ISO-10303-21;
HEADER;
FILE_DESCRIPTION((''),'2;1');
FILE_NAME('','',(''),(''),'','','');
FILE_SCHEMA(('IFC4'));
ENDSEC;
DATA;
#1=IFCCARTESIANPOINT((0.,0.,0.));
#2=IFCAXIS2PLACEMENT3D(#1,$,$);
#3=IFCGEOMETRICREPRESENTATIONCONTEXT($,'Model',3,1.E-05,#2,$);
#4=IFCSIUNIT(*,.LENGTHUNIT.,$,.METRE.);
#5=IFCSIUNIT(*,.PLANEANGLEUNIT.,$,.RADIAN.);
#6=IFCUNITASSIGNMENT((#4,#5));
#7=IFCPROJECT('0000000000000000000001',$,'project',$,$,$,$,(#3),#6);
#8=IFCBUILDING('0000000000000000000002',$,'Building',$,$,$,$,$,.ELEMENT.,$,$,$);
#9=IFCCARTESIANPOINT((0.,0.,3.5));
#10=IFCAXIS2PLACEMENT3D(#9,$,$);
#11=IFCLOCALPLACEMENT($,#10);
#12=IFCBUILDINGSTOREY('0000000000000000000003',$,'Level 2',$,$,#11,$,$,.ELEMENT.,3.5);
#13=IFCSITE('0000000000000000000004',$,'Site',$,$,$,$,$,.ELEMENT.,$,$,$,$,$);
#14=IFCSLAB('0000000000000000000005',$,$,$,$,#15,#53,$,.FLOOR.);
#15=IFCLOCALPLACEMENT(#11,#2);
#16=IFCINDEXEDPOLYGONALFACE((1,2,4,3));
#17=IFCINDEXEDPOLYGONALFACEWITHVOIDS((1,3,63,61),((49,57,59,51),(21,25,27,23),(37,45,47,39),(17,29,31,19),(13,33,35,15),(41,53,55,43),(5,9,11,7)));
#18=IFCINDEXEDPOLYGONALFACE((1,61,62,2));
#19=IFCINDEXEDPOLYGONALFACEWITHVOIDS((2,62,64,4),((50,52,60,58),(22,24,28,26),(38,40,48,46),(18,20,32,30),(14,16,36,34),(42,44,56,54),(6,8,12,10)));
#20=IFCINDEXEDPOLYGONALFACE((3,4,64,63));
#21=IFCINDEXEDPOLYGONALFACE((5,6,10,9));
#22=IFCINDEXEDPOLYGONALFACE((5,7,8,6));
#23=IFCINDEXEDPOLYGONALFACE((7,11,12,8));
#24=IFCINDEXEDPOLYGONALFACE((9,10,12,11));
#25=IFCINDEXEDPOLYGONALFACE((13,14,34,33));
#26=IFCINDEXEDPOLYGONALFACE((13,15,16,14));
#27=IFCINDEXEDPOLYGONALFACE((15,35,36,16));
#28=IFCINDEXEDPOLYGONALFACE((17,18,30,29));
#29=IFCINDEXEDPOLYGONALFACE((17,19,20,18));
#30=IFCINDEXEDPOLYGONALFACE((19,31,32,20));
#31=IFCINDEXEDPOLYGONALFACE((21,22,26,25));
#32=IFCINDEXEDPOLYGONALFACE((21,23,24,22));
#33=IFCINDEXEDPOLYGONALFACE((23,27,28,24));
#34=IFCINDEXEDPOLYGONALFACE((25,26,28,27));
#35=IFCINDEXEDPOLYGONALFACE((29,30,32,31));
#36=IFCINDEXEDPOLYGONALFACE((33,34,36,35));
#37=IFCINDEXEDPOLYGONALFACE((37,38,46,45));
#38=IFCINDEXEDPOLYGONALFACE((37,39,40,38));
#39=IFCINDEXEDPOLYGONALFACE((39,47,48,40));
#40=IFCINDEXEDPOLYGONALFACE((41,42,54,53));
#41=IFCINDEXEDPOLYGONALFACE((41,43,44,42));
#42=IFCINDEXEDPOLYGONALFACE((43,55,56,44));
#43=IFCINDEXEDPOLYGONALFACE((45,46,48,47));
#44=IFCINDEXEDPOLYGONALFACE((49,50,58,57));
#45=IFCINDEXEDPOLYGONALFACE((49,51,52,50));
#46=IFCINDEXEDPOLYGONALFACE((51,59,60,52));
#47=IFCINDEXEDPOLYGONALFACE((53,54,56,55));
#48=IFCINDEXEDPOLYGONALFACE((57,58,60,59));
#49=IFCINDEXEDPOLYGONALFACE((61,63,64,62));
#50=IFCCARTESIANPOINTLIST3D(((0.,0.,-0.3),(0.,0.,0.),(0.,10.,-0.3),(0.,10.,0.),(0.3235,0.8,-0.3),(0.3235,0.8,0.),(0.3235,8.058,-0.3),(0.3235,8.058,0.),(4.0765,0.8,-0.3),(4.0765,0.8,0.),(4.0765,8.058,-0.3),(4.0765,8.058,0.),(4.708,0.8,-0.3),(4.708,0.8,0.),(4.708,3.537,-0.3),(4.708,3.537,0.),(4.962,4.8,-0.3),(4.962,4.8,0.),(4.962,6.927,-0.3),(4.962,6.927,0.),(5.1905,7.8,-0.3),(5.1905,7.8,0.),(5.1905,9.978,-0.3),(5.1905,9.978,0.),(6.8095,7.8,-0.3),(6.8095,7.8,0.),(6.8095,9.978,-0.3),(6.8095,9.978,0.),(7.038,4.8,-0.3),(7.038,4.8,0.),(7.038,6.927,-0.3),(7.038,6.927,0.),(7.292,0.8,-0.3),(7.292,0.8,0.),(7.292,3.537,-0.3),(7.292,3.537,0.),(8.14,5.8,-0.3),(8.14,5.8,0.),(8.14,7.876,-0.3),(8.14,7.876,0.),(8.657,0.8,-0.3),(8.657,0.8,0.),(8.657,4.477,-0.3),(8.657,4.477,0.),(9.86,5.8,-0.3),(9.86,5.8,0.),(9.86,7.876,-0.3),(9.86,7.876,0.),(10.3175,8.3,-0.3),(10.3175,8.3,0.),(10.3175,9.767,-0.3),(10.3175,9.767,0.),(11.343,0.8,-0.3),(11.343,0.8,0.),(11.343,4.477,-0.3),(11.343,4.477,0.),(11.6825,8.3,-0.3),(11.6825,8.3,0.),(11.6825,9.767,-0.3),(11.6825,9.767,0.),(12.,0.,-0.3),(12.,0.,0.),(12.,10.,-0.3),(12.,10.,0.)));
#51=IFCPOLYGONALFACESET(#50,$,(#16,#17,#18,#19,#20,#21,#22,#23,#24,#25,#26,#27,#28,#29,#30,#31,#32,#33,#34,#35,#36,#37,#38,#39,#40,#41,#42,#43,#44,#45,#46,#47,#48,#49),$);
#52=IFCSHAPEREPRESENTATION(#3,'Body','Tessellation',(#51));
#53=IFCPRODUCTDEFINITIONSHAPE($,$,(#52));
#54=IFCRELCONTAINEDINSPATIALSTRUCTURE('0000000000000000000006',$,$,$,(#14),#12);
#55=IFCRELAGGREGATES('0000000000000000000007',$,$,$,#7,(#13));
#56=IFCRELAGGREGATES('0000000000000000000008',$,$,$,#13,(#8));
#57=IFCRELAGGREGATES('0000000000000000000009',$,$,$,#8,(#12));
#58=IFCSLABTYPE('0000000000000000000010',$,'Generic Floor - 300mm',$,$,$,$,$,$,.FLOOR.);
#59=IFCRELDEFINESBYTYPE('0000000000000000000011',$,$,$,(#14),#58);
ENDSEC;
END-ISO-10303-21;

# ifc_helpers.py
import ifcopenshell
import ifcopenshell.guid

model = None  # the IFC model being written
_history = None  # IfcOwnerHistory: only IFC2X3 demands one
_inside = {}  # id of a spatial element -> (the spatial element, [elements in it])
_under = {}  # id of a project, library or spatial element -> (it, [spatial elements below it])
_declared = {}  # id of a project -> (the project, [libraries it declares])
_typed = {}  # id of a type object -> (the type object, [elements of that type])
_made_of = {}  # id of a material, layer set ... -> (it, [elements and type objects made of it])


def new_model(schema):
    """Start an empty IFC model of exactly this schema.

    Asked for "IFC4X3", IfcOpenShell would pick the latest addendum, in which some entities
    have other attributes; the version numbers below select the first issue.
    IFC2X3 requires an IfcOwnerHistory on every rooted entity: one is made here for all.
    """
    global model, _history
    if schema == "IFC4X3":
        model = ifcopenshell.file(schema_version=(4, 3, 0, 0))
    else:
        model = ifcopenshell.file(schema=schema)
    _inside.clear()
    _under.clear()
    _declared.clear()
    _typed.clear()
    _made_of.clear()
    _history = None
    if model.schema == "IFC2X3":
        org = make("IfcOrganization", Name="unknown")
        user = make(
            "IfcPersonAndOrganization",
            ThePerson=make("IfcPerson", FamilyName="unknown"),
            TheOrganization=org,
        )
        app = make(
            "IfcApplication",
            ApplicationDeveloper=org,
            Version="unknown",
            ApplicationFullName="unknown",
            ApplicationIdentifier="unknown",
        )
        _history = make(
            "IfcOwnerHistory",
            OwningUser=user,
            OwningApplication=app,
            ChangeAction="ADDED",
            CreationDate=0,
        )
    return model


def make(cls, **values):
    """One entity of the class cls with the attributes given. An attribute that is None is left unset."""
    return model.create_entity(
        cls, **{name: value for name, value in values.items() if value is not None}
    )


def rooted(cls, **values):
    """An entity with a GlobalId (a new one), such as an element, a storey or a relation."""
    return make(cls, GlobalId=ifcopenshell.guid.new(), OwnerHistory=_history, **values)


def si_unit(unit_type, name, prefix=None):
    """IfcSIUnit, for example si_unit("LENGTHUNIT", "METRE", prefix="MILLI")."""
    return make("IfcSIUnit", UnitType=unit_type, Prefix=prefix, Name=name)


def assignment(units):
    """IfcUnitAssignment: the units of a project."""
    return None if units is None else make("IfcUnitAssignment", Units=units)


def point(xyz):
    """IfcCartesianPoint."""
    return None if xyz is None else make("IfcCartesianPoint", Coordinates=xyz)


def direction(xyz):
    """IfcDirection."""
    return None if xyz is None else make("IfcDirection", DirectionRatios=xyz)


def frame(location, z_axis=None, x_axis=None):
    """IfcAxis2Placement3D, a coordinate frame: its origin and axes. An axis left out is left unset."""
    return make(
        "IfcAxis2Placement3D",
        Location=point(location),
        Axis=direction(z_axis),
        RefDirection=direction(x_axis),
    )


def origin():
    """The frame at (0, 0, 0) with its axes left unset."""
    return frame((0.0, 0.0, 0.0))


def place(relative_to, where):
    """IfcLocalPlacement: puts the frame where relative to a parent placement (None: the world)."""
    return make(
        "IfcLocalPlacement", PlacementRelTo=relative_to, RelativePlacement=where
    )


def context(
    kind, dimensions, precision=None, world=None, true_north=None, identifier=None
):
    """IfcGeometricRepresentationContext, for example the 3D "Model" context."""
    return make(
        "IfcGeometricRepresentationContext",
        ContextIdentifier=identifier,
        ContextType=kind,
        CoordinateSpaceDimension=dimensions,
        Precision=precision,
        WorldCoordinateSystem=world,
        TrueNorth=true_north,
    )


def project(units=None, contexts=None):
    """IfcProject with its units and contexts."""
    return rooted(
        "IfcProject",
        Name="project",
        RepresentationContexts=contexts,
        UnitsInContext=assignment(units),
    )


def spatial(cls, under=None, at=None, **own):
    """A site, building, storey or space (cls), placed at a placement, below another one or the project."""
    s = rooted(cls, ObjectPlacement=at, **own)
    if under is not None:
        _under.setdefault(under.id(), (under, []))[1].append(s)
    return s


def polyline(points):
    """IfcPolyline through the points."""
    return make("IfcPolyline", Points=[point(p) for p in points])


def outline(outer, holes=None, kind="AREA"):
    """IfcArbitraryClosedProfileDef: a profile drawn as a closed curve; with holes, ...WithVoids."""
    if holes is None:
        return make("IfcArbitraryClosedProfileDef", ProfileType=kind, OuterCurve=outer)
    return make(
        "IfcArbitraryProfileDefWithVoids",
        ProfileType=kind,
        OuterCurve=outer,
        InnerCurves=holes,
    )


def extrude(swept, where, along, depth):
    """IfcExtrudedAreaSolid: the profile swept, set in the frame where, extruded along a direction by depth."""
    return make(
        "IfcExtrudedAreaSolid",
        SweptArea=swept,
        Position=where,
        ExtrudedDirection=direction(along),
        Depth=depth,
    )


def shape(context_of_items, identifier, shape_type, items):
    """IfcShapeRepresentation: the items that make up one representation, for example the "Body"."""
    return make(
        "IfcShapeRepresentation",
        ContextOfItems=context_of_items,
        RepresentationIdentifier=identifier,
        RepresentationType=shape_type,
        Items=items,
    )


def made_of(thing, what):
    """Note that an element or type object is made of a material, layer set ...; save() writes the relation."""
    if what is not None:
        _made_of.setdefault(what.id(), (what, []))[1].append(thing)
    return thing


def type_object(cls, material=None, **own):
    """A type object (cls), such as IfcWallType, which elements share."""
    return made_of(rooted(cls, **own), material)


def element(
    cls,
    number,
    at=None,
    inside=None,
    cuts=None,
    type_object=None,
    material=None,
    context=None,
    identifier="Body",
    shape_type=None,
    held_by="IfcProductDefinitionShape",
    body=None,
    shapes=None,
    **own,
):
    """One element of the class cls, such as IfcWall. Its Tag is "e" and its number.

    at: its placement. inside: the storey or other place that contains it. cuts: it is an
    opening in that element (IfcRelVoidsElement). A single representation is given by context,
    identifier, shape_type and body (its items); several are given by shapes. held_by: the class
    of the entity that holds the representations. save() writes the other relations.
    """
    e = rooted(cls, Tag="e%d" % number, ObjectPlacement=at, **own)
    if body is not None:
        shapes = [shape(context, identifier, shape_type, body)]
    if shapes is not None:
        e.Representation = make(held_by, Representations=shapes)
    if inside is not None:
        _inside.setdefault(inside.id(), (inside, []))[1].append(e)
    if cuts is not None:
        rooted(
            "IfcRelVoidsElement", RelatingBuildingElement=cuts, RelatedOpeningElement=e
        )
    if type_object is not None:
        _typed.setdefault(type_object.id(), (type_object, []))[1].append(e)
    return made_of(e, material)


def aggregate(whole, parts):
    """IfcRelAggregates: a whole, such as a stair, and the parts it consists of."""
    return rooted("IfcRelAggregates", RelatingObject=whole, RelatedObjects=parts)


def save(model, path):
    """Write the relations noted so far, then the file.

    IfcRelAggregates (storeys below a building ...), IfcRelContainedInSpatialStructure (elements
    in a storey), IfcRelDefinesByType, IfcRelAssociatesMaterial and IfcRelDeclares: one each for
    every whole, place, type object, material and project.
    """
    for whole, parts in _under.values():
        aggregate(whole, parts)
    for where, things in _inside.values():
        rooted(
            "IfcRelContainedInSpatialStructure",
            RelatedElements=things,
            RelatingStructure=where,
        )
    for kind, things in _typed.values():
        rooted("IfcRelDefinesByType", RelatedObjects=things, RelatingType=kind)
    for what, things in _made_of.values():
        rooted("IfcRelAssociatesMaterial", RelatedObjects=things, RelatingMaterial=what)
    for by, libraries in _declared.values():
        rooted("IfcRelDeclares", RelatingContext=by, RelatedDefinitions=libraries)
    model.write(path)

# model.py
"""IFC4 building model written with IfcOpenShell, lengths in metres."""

from ifc_helpers import new_model, si_unit, frame, origin, place, context, project, spatial, polyline, outline, extrude, type_object, element, save


model = new_model("IFC4")

# Units and contexts
model_context = context("Model", 3, precision=1e-05, world=origin())
ifc_project = project(units=[si_unit("LENGTHUNIT", "METRE"), si_unit("PLANEANGLEUNIT", "RADIAN")], contexts=[model_context])

# Site, building, storey
site = spatial("IfcSite", under=ifc_project, Name="Site", CompositionType="ELEMENT")
building = spatial("IfcBuilding", under=site, Name="Building", CompositionType="ELEMENT")
storey_placement = place(None, frame((0.0, 0.0, 3.5)))
storey = spatial("IfcBuildingStorey", under=building, at=storey_placement, Name="Level 2", CompositionType="ELEMENT", Elevation=3.5)

# Slab, openings
slab_type = type_object("IfcSlabType", Name="Generic Floor - 300mm", PredefinedType="FLOOR")
slab_placement = place(None, frame((0.0, 0.0, 3.5)))
slab = element("IfcSlab", 1, at=slab_placement, inside=storey, type_object=slab_type, PredefinedType="FLOOR", context=model_context, shape_type="SweptSolid", body=[
    extrude(outline(polyline([(0.0, 0.0), (12.0, 0.0), (12.0, 10.0), (0.0, 10.0), (0.0, 0.0)])), origin(), (0.0, 0.0, -1.0), 0.3),
])
opening_1_placement = place(None, frame((0.0, 0.0, 3.501)))
element("IfcOpeningElement", 2, at=opening_1_placement, cuts=slab, PredefinedType="OPENING", context=model_context, shape_type="SweptSolid", body=[
    extrude(outline(polyline([(0.3235, 0.8), (4.0765, 0.8), (4.0765, 8.058), (0.3235, 8.058), (0.3235, 0.8)])), origin(), (0.0, 0.0, -1.0), 0.302),
])
opening_2_placement = place(None, frame((0.0, 0.0, 3.501)))
element("IfcOpeningElement", 3, at=opening_2_placement, cuts=slab, PredefinedType="OPENING", context=model_context, shape_type="SweptSolid", body=[
    extrude(outline(polyline([(4.708, 0.8), (7.292, 0.8), (7.292, 3.537), (4.708, 3.537), (4.708, 0.8)])), origin(), (0.0, 0.0, -1.0), 0.302),
])
opening_3_placement = place(None, frame((0.0, 0.0, 3.501)))
element("IfcOpeningElement", 4, at=opening_3_placement, cuts=slab, PredefinedType="OPENING", context=model_context, shape_type="SweptSolid", body=[
    extrude(outline(polyline([(8.657, 0.8), (11.343, 0.8), (11.343, 4.477), (8.657, 4.477), (8.657, 0.8)])), origin(), (0.0, 0.0, -1.0), 0.302),
])
opening_4_placement = place(None, frame((0.0, 0.0, 3.501)))
element("IfcOpeningElement", 5, at=opening_4_placement, cuts=slab, PredefinedType="OPENING", context=model_context, shape_type="SweptSolid", body=[
    extrude(outline(polyline([(4.962, 4.8), (7.038, 4.8), (7.038, 6.927), (4.962, 6.927), (4.962, 4.8)])), origin(), (0.0, 0.0, -1.0), 0.302),
])
opening_5_placement = place(None, frame((0.0, 0.0, 3.501)))
element("IfcOpeningElement", 6, at=opening_5_placement, cuts=slab, PredefinedType="OPENING", context=model_context, shape_type="SweptSolid", body=[
    extrude(outline(polyline([(8.14, 5.8), (9.86, 5.8), (9.86, 7.876), (8.14, 7.876), (8.14, 5.8)])), origin(), (0.0, 0.0, -1.0), 0.302),
])
opening_6_placement = place(None, frame((0.0, 0.0, 3.501)))
element("IfcOpeningElement", 7, at=opening_6_placement, cuts=slab, PredefinedType="OPENING", context=model_context, shape_type="SweptSolid", body=[
    extrude(outline(polyline([(5.1905, 7.8), (6.8095, 7.8), (6.8095, 9.978), (5.1905, 9.978), (5.1905, 7.8)])), origin(), (0.0, 0.0, -1.0), 0.302),
])
opening_7_placement = place(None, frame((0.0, 0.0, 3.501)))
element("IfcOpeningElement", 8, at=opening_7_placement, cuts=slab, PredefinedType="OPENING", context=model_context, shape_type="SweptSolid", body=[
    extrude(outline(polyline([(10.3175, 8.3), (11.6825, 8.3), (11.6825, 9.767), (10.3175, 9.767), (10.3175, 8.3)])), origin(), (0.0, 0.0, -1.0), 0.302),
])

save(model, "model.ifc")
